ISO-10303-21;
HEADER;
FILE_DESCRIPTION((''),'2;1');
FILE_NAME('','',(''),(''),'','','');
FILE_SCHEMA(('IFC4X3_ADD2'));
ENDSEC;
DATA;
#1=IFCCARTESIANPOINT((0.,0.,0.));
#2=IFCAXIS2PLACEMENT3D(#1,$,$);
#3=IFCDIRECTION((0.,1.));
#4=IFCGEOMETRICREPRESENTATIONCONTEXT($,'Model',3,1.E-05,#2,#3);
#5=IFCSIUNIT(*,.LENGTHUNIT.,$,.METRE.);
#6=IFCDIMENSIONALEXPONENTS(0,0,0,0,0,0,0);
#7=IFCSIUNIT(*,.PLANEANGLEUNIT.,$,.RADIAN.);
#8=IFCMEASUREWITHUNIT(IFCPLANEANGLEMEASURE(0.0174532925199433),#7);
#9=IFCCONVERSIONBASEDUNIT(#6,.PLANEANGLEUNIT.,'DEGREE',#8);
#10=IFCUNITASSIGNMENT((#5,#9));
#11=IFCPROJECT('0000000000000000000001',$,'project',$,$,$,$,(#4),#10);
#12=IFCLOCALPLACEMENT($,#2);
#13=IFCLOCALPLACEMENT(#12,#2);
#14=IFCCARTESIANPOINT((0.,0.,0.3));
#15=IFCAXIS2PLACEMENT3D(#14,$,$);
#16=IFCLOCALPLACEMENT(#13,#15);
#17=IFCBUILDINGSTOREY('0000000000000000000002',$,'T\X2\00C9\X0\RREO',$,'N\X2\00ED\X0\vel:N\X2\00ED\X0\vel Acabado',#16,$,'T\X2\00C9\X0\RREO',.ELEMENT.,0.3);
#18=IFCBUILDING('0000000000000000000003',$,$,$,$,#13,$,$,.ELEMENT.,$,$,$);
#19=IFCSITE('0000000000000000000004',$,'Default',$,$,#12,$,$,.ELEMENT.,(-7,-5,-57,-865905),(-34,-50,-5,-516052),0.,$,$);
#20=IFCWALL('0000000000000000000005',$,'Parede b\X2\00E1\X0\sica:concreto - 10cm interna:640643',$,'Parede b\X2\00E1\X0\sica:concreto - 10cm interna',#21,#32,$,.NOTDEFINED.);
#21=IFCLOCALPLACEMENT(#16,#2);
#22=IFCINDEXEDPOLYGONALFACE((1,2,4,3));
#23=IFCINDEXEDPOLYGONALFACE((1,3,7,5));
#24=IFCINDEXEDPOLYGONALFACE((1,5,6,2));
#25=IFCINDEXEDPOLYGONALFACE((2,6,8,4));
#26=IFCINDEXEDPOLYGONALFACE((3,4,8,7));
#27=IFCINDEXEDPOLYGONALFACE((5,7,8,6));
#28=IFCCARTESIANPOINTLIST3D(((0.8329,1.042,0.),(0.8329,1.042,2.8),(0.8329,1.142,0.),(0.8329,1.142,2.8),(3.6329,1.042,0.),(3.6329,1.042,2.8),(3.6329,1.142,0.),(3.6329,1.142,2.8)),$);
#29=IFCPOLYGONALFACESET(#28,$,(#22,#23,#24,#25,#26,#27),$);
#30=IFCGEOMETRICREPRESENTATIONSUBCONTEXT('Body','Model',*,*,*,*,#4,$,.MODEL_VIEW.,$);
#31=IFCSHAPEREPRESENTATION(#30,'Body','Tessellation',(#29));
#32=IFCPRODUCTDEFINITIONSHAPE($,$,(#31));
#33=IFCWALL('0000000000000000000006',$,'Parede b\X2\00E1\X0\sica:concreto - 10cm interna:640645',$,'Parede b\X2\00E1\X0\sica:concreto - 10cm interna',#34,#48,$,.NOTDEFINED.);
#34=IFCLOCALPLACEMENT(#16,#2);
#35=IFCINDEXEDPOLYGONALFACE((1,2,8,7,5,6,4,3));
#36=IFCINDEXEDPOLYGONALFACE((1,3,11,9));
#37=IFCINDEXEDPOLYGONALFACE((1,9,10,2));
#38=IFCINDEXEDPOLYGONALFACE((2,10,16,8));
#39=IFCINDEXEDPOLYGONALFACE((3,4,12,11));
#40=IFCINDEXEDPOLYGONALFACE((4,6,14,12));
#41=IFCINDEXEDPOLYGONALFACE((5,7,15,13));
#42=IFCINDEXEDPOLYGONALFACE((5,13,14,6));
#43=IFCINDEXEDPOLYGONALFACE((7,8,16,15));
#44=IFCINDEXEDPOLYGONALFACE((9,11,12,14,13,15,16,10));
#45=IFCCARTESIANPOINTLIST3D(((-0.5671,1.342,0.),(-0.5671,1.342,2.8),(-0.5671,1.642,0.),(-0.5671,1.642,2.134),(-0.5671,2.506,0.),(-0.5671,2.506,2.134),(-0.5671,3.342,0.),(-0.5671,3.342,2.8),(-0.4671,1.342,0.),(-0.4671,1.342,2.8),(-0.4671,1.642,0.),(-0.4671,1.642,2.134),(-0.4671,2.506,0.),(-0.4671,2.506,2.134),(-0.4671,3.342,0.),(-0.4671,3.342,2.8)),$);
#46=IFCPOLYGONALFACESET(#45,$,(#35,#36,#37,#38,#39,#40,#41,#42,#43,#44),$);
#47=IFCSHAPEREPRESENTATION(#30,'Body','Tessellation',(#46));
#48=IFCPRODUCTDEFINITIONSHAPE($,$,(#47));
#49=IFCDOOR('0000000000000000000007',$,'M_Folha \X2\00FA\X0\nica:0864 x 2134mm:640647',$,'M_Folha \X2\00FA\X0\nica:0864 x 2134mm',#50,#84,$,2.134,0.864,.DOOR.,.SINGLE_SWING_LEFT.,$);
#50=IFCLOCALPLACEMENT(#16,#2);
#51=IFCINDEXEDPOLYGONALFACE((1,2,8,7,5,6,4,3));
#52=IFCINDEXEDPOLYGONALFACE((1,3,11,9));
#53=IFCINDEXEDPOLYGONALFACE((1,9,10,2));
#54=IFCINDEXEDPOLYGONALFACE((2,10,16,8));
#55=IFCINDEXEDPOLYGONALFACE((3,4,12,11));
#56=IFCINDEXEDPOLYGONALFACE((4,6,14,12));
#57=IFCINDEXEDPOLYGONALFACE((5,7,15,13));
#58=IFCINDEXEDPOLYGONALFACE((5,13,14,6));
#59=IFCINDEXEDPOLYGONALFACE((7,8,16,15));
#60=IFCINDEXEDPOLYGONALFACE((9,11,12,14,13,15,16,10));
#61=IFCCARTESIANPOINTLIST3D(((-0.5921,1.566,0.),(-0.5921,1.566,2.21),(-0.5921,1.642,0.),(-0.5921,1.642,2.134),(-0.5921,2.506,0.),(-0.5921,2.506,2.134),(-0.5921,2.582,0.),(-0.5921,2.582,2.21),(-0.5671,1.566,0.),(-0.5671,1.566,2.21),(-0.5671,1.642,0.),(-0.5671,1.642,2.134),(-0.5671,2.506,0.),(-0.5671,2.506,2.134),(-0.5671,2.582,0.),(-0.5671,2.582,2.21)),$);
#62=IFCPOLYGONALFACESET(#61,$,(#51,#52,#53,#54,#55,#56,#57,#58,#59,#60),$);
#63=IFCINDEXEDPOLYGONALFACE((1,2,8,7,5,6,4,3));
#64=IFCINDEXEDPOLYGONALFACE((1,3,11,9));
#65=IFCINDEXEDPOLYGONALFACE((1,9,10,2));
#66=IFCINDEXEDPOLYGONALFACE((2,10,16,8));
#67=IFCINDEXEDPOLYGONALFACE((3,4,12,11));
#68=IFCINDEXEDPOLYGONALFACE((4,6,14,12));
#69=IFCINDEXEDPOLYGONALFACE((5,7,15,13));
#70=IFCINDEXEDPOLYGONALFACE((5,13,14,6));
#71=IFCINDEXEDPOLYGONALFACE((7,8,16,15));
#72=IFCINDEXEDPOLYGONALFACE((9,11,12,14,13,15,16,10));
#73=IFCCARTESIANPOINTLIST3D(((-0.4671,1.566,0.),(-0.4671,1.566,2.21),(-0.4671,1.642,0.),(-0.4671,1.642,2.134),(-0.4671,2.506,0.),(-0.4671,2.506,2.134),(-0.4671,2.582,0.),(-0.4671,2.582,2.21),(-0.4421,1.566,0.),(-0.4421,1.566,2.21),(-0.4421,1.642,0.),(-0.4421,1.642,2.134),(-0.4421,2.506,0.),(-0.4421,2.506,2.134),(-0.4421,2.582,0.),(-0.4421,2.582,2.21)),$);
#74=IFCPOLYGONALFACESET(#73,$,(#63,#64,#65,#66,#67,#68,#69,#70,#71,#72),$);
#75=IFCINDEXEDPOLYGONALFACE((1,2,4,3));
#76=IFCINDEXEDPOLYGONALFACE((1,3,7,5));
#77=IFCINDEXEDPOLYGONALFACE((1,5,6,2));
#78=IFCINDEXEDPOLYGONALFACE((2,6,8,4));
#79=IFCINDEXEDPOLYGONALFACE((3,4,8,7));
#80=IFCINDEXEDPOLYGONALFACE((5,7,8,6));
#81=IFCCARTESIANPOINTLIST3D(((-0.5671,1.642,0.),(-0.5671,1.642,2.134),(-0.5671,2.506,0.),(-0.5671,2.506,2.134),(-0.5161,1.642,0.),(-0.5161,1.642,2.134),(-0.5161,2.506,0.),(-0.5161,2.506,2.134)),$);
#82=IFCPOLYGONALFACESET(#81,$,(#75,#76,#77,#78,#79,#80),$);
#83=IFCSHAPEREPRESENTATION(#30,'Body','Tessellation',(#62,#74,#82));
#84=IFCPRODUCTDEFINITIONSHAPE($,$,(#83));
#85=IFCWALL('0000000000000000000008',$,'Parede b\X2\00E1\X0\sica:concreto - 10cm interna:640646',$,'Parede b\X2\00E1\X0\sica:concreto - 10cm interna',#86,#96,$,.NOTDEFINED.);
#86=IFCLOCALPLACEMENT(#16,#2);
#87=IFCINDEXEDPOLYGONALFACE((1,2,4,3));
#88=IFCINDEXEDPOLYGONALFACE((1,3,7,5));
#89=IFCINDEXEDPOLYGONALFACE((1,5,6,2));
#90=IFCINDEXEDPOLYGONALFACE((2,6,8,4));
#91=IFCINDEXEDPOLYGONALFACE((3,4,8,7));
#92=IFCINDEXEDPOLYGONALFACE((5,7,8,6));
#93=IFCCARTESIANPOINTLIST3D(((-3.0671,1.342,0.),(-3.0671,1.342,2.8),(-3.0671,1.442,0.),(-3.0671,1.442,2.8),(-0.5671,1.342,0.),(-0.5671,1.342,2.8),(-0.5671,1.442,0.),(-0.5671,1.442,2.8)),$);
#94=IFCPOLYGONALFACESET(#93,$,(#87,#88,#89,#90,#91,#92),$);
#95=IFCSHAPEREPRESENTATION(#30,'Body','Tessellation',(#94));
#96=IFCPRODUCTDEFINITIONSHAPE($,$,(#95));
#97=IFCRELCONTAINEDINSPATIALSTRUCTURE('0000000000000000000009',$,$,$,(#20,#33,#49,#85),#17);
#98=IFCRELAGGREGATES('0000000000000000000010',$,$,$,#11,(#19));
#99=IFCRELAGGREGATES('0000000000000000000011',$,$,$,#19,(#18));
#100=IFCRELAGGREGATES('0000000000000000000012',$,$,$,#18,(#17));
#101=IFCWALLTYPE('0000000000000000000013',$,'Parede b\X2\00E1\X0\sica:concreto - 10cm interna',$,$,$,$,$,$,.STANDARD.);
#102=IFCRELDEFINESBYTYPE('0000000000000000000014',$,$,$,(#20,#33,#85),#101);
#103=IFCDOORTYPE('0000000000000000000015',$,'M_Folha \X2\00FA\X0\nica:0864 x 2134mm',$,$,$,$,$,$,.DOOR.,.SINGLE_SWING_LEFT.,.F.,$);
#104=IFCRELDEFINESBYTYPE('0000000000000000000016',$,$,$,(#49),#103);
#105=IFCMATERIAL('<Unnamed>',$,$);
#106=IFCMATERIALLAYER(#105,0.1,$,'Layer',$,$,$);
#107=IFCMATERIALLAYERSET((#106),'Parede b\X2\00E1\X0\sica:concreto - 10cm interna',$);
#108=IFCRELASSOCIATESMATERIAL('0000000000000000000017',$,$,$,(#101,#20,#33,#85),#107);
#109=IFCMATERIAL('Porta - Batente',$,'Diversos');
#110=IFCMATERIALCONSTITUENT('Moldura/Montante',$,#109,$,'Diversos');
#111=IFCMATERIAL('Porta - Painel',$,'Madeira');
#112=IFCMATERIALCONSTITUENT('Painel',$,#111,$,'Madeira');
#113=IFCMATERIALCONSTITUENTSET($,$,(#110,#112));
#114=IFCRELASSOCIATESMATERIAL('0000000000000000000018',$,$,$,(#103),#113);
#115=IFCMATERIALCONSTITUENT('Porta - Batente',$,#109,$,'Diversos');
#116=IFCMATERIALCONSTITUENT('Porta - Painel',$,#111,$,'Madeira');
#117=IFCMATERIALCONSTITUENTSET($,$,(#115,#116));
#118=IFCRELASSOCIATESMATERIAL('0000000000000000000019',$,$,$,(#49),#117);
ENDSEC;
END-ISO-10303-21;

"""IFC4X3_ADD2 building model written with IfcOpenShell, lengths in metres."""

from ifc_helpers import new_model, entity, si_unit, converted_unit, direction, frame, frame_2d, origin, origin_2d_with_axis, place, context, subcontext, project, spatial, polyline, rectangle, outline, extrude, source, transform, mapped, material, layer, layer_set, constituent, constituent_set, type_object, type_shapes, element, fill, save


model = new_model("IFC4X3_ADD2")

# Units and contexts
model_context = context("Model", 3, precision=1e-05, world=origin(), true_north=direction((0.0, 1.0)))
body_context = subcontext(model_context, "Body", "Model", "MODEL_VIEW")
ifc_project = project(units=[si_unit("LENGTHUNIT", "METRE"), converted_unit("PLANEANGLEUNIT", "DEGREE", entity("IfcPlaneAngleMeasure", 0.0174532925199433), si_unit("PLANEANGLEUNIT", "RADIAN"), dimensions=[0, 0, 0, 0, 0, 0, 0])], contexts=[model_context])

# Site, building, storey
site_placement = place(None, origin())
site = spatial("IfcSite", under=ifc_project, at=site_placement, Name="Default", CompositionType="ELEMENT", RefLatitude=(-7, -5, -57, -865905), RefLongitude=(-34, -50, -5, -516052), RefElevation=0.0)
building_placement = place(site_placement, origin())
building = spatial("IfcBuilding", under=site, at=building_placement, CompositionType="ELEMENT")
storey_placement = place(building_placement, frame((0.0, 0.0, 0.3)))
storey = spatial("IfcBuildingStorey", under=building, at=storey_placement, Name="TÉRREO", ObjectType="Nível:Nível Acabado", LongName="TÉRREO", CompositionType="ELEMENT", Elevation=0.3)

# Shared definitions
ifc_material_1 = material(Name="<Unnamed>")

# Shared definitions
ifc_material_2 = material(Name="Porta - Batente", Category="Diversos")
ifc_material_3 = material(Name="Porta - Painel", Category="Madeira")

# Wall
ifc_layer_1 = layer(ifc_material_1, 0.1, Name="Layer")
ifc_layer_set_1 = layer_set([ifc_layer_1], Name="Parede básica:concreto - 10cm interna")
wall_type_1 = type_object("IfcWallType", Name="Parede básica:concreto - 10cm interna", PredefinedType="STANDARD", material=ifc_layer_set_1)
wall_1_placement = place(storey_placement, frame((3.6329, 1.092, 0.0), z_axis=(0.0, 0.0, 1.0), x_axis=(-1.0, 0.0, 0.0)))
element("IfcWall", 1, at=wall_1_placement, inside=storey, type_object=wall_type_1, material=ifc_layer_set_1, Name="Parede básica:concreto - 10cm interna:640643", ObjectType="Parede básica:concreto - 10cm interna", PredefinedType="NOTDEFINED", context=body_context, shape_type="SweptSolid", body=[
    extrude(rectangle(XDim=2.8, YDim=0.1, at=frame_2d((1.4, 0.0), x_axis=(-1.0, 0.0))), origin(), (0.0, 0.0, 1.0), 2.8),
])

# Wall, opening, door
wall_2_placement = place(storey_placement, frame((-0.5171, 3.342, 0.0), z_axis=(0.0, 0.0, 1.0), x_axis=(0.0, -1.0, 0.0)))
wall_2 = element("IfcWall", 2, at=wall_2_placement, inside=storey, type_object=wall_type_1, material=ifc_layer_set_1, Name="Parede básica:concreto - 10cm interna:640645", ObjectType="Parede básica:concreto - 10cm interna", PredefinedType="NOTDEFINED", context=body_context, shape_type="SweptSolid", body=[
    extrude(rectangle(XDim=2.0, YDim=0.1, at=frame_2d((1.0, 0.0), x_axis=(1.0, 0.0))), origin(), (0.0, 0.0, 1.0), 2.8),
])
opening_1_placement = place(wall_2_placement, frame((1.7, 0.05, 0.0)))
opening_1 = element("IfcOpeningElement", 3, at=opening_1_placement, cuts=wall_2, PredefinedType="OPENING", context=body_context, shape_type="SweptSolid", body=[
    extrude(rectangle(XDim=0.864, YDim=2.134, at=frame_2d((1.067, 0.432), x_axis=(0.0, -1.0))), frame((0.0, 0.0, 0.0), z_axis=(0.0, -1.0, 0.0), x_axis=(0.0, 0.0, 1.0)), (0.0, 0.0, 1.0), 0.1),
])
ifc_constituent_1 = constituent(ifc_material_2, Name="Porta - Batente", Category="Diversos")
ifc_constituent_2 = constituent(ifc_material_3, Name="Porta - Painel", Category="Madeira")
ifc_constituent_set_1 = constituent_set(constituents=[ifc_constituent_1, ifc_constituent_2])
ifc_constituent_3 = constituent(ifc_material_2, Name="Moldura/Montante", Category="Diversos")
ifc_constituent_4 = constituent(ifc_material_3, Name="Painel", Category="Madeira")
ifc_constituent_set_2 = constituent_set(constituents=[ifc_constituent_3, ifc_constituent_4])
door_type_1 = type_object("IfcDoorType", Name="M_Folha única:0864 x 2134mm", OperationType="SINGLE_SWING_LEFT", ParameterTakesPrecedence=False, PredefinedType="DOOR", material=ifc_constituent_set_2)
shared_shape_1 = source(origin(), body_context, "Body", "SweptSolid", [
    extrude(outline(polyline([(-0.508, -1.124), (0.508, -1.124), (0.508, 1.086), (0.432, 1.086), (0.432, -1.048), (-0.432, -1.048), (-0.432, 1.086), (-0.508, 1.086), (-0.508, -1.124)])), frame((0.432, 0.125, 1.086), z_axis=(0.0, -1.0, 0.0), x_axis=(-1.0, 0.0, 0.0)), (0.0, 0.0, 1.0), 0.025),
    extrude(outline(polyline([(-1.124, -0.508), (1.086, -0.508), (1.086, -0.432), (-1.048, -0.432), (-1.048, 0.432), (1.086, 0.432), (1.086, 0.508), (-1.124, 0.508), (-1.124, -0.508)])), frame((0.432, 0.0, 1.086), z_axis=(0.0, -1.0, 0.0), x_axis=(0.0, 0.0, -1.0)), (0.0, 0.0, 1.0), 0.025),
    extrude(rectangle(XDim=0.864, YDim=0.051, at=origin_2d_with_axis()), frame((0.432, 0.0745, 0.0)), (0.0, 0.0, 1.0), 2.134),
])
type_shapes(door_type_1, [shared_shape_1])
door_1_placement = place(opening_1_placement, frame((0.0, 0.0, 0.0), z_axis=(0.0, 0.0, 1.0), x_axis=(-1.0, 0.0, 0.0)))
door_1 = element("IfcDoor", 4, at=door_1_placement, inside=storey, type_object=door_type_1, material=ifc_constituent_set_1, Name="M_Folha única:0864 x 2134mm:640647", ObjectType="M_Folha única:0864 x 2134mm", OperationType="SINGLE_SWING_LEFT", OverallHeight=2.134, OverallWidth=0.864, PredefinedType="DOOR", context=body_context, shape_type="MappedRepresentation", body=[
    mapped(shared_shape_1, transform((0.0, 0.0, 0.0), scale=1.0)),
])
fill(opening_1, door_1)

# Wall
wall_3_placement = place(storey_placement, frame((-0.5671, 1.392, 0.0), z_axis=(0.0, 0.0, 1.0), x_axis=(-1.0, 0.0, 0.0)))
element("IfcWall", 5, at=wall_3_placement, inside=storey, type_object=wall_type_1, material=ifc_layer_set_1, Name="Parede básica:concreto - 10cm interna:640646", ObjectType="Parede básica:concreto - 10cm interna", PredefinedType="NOTDEFINED", context=body_context, shape_type="SweptSolid", body=[
    extrude(rectangle(XDim=2.5, YDim=0.1, at=frame_2d((1.25, 0.0), x_axis=(-1.0, 0.0))), origin(), (0.0, 0.0, 1.0), 2.8),
])

save(model, "model.ifc")
